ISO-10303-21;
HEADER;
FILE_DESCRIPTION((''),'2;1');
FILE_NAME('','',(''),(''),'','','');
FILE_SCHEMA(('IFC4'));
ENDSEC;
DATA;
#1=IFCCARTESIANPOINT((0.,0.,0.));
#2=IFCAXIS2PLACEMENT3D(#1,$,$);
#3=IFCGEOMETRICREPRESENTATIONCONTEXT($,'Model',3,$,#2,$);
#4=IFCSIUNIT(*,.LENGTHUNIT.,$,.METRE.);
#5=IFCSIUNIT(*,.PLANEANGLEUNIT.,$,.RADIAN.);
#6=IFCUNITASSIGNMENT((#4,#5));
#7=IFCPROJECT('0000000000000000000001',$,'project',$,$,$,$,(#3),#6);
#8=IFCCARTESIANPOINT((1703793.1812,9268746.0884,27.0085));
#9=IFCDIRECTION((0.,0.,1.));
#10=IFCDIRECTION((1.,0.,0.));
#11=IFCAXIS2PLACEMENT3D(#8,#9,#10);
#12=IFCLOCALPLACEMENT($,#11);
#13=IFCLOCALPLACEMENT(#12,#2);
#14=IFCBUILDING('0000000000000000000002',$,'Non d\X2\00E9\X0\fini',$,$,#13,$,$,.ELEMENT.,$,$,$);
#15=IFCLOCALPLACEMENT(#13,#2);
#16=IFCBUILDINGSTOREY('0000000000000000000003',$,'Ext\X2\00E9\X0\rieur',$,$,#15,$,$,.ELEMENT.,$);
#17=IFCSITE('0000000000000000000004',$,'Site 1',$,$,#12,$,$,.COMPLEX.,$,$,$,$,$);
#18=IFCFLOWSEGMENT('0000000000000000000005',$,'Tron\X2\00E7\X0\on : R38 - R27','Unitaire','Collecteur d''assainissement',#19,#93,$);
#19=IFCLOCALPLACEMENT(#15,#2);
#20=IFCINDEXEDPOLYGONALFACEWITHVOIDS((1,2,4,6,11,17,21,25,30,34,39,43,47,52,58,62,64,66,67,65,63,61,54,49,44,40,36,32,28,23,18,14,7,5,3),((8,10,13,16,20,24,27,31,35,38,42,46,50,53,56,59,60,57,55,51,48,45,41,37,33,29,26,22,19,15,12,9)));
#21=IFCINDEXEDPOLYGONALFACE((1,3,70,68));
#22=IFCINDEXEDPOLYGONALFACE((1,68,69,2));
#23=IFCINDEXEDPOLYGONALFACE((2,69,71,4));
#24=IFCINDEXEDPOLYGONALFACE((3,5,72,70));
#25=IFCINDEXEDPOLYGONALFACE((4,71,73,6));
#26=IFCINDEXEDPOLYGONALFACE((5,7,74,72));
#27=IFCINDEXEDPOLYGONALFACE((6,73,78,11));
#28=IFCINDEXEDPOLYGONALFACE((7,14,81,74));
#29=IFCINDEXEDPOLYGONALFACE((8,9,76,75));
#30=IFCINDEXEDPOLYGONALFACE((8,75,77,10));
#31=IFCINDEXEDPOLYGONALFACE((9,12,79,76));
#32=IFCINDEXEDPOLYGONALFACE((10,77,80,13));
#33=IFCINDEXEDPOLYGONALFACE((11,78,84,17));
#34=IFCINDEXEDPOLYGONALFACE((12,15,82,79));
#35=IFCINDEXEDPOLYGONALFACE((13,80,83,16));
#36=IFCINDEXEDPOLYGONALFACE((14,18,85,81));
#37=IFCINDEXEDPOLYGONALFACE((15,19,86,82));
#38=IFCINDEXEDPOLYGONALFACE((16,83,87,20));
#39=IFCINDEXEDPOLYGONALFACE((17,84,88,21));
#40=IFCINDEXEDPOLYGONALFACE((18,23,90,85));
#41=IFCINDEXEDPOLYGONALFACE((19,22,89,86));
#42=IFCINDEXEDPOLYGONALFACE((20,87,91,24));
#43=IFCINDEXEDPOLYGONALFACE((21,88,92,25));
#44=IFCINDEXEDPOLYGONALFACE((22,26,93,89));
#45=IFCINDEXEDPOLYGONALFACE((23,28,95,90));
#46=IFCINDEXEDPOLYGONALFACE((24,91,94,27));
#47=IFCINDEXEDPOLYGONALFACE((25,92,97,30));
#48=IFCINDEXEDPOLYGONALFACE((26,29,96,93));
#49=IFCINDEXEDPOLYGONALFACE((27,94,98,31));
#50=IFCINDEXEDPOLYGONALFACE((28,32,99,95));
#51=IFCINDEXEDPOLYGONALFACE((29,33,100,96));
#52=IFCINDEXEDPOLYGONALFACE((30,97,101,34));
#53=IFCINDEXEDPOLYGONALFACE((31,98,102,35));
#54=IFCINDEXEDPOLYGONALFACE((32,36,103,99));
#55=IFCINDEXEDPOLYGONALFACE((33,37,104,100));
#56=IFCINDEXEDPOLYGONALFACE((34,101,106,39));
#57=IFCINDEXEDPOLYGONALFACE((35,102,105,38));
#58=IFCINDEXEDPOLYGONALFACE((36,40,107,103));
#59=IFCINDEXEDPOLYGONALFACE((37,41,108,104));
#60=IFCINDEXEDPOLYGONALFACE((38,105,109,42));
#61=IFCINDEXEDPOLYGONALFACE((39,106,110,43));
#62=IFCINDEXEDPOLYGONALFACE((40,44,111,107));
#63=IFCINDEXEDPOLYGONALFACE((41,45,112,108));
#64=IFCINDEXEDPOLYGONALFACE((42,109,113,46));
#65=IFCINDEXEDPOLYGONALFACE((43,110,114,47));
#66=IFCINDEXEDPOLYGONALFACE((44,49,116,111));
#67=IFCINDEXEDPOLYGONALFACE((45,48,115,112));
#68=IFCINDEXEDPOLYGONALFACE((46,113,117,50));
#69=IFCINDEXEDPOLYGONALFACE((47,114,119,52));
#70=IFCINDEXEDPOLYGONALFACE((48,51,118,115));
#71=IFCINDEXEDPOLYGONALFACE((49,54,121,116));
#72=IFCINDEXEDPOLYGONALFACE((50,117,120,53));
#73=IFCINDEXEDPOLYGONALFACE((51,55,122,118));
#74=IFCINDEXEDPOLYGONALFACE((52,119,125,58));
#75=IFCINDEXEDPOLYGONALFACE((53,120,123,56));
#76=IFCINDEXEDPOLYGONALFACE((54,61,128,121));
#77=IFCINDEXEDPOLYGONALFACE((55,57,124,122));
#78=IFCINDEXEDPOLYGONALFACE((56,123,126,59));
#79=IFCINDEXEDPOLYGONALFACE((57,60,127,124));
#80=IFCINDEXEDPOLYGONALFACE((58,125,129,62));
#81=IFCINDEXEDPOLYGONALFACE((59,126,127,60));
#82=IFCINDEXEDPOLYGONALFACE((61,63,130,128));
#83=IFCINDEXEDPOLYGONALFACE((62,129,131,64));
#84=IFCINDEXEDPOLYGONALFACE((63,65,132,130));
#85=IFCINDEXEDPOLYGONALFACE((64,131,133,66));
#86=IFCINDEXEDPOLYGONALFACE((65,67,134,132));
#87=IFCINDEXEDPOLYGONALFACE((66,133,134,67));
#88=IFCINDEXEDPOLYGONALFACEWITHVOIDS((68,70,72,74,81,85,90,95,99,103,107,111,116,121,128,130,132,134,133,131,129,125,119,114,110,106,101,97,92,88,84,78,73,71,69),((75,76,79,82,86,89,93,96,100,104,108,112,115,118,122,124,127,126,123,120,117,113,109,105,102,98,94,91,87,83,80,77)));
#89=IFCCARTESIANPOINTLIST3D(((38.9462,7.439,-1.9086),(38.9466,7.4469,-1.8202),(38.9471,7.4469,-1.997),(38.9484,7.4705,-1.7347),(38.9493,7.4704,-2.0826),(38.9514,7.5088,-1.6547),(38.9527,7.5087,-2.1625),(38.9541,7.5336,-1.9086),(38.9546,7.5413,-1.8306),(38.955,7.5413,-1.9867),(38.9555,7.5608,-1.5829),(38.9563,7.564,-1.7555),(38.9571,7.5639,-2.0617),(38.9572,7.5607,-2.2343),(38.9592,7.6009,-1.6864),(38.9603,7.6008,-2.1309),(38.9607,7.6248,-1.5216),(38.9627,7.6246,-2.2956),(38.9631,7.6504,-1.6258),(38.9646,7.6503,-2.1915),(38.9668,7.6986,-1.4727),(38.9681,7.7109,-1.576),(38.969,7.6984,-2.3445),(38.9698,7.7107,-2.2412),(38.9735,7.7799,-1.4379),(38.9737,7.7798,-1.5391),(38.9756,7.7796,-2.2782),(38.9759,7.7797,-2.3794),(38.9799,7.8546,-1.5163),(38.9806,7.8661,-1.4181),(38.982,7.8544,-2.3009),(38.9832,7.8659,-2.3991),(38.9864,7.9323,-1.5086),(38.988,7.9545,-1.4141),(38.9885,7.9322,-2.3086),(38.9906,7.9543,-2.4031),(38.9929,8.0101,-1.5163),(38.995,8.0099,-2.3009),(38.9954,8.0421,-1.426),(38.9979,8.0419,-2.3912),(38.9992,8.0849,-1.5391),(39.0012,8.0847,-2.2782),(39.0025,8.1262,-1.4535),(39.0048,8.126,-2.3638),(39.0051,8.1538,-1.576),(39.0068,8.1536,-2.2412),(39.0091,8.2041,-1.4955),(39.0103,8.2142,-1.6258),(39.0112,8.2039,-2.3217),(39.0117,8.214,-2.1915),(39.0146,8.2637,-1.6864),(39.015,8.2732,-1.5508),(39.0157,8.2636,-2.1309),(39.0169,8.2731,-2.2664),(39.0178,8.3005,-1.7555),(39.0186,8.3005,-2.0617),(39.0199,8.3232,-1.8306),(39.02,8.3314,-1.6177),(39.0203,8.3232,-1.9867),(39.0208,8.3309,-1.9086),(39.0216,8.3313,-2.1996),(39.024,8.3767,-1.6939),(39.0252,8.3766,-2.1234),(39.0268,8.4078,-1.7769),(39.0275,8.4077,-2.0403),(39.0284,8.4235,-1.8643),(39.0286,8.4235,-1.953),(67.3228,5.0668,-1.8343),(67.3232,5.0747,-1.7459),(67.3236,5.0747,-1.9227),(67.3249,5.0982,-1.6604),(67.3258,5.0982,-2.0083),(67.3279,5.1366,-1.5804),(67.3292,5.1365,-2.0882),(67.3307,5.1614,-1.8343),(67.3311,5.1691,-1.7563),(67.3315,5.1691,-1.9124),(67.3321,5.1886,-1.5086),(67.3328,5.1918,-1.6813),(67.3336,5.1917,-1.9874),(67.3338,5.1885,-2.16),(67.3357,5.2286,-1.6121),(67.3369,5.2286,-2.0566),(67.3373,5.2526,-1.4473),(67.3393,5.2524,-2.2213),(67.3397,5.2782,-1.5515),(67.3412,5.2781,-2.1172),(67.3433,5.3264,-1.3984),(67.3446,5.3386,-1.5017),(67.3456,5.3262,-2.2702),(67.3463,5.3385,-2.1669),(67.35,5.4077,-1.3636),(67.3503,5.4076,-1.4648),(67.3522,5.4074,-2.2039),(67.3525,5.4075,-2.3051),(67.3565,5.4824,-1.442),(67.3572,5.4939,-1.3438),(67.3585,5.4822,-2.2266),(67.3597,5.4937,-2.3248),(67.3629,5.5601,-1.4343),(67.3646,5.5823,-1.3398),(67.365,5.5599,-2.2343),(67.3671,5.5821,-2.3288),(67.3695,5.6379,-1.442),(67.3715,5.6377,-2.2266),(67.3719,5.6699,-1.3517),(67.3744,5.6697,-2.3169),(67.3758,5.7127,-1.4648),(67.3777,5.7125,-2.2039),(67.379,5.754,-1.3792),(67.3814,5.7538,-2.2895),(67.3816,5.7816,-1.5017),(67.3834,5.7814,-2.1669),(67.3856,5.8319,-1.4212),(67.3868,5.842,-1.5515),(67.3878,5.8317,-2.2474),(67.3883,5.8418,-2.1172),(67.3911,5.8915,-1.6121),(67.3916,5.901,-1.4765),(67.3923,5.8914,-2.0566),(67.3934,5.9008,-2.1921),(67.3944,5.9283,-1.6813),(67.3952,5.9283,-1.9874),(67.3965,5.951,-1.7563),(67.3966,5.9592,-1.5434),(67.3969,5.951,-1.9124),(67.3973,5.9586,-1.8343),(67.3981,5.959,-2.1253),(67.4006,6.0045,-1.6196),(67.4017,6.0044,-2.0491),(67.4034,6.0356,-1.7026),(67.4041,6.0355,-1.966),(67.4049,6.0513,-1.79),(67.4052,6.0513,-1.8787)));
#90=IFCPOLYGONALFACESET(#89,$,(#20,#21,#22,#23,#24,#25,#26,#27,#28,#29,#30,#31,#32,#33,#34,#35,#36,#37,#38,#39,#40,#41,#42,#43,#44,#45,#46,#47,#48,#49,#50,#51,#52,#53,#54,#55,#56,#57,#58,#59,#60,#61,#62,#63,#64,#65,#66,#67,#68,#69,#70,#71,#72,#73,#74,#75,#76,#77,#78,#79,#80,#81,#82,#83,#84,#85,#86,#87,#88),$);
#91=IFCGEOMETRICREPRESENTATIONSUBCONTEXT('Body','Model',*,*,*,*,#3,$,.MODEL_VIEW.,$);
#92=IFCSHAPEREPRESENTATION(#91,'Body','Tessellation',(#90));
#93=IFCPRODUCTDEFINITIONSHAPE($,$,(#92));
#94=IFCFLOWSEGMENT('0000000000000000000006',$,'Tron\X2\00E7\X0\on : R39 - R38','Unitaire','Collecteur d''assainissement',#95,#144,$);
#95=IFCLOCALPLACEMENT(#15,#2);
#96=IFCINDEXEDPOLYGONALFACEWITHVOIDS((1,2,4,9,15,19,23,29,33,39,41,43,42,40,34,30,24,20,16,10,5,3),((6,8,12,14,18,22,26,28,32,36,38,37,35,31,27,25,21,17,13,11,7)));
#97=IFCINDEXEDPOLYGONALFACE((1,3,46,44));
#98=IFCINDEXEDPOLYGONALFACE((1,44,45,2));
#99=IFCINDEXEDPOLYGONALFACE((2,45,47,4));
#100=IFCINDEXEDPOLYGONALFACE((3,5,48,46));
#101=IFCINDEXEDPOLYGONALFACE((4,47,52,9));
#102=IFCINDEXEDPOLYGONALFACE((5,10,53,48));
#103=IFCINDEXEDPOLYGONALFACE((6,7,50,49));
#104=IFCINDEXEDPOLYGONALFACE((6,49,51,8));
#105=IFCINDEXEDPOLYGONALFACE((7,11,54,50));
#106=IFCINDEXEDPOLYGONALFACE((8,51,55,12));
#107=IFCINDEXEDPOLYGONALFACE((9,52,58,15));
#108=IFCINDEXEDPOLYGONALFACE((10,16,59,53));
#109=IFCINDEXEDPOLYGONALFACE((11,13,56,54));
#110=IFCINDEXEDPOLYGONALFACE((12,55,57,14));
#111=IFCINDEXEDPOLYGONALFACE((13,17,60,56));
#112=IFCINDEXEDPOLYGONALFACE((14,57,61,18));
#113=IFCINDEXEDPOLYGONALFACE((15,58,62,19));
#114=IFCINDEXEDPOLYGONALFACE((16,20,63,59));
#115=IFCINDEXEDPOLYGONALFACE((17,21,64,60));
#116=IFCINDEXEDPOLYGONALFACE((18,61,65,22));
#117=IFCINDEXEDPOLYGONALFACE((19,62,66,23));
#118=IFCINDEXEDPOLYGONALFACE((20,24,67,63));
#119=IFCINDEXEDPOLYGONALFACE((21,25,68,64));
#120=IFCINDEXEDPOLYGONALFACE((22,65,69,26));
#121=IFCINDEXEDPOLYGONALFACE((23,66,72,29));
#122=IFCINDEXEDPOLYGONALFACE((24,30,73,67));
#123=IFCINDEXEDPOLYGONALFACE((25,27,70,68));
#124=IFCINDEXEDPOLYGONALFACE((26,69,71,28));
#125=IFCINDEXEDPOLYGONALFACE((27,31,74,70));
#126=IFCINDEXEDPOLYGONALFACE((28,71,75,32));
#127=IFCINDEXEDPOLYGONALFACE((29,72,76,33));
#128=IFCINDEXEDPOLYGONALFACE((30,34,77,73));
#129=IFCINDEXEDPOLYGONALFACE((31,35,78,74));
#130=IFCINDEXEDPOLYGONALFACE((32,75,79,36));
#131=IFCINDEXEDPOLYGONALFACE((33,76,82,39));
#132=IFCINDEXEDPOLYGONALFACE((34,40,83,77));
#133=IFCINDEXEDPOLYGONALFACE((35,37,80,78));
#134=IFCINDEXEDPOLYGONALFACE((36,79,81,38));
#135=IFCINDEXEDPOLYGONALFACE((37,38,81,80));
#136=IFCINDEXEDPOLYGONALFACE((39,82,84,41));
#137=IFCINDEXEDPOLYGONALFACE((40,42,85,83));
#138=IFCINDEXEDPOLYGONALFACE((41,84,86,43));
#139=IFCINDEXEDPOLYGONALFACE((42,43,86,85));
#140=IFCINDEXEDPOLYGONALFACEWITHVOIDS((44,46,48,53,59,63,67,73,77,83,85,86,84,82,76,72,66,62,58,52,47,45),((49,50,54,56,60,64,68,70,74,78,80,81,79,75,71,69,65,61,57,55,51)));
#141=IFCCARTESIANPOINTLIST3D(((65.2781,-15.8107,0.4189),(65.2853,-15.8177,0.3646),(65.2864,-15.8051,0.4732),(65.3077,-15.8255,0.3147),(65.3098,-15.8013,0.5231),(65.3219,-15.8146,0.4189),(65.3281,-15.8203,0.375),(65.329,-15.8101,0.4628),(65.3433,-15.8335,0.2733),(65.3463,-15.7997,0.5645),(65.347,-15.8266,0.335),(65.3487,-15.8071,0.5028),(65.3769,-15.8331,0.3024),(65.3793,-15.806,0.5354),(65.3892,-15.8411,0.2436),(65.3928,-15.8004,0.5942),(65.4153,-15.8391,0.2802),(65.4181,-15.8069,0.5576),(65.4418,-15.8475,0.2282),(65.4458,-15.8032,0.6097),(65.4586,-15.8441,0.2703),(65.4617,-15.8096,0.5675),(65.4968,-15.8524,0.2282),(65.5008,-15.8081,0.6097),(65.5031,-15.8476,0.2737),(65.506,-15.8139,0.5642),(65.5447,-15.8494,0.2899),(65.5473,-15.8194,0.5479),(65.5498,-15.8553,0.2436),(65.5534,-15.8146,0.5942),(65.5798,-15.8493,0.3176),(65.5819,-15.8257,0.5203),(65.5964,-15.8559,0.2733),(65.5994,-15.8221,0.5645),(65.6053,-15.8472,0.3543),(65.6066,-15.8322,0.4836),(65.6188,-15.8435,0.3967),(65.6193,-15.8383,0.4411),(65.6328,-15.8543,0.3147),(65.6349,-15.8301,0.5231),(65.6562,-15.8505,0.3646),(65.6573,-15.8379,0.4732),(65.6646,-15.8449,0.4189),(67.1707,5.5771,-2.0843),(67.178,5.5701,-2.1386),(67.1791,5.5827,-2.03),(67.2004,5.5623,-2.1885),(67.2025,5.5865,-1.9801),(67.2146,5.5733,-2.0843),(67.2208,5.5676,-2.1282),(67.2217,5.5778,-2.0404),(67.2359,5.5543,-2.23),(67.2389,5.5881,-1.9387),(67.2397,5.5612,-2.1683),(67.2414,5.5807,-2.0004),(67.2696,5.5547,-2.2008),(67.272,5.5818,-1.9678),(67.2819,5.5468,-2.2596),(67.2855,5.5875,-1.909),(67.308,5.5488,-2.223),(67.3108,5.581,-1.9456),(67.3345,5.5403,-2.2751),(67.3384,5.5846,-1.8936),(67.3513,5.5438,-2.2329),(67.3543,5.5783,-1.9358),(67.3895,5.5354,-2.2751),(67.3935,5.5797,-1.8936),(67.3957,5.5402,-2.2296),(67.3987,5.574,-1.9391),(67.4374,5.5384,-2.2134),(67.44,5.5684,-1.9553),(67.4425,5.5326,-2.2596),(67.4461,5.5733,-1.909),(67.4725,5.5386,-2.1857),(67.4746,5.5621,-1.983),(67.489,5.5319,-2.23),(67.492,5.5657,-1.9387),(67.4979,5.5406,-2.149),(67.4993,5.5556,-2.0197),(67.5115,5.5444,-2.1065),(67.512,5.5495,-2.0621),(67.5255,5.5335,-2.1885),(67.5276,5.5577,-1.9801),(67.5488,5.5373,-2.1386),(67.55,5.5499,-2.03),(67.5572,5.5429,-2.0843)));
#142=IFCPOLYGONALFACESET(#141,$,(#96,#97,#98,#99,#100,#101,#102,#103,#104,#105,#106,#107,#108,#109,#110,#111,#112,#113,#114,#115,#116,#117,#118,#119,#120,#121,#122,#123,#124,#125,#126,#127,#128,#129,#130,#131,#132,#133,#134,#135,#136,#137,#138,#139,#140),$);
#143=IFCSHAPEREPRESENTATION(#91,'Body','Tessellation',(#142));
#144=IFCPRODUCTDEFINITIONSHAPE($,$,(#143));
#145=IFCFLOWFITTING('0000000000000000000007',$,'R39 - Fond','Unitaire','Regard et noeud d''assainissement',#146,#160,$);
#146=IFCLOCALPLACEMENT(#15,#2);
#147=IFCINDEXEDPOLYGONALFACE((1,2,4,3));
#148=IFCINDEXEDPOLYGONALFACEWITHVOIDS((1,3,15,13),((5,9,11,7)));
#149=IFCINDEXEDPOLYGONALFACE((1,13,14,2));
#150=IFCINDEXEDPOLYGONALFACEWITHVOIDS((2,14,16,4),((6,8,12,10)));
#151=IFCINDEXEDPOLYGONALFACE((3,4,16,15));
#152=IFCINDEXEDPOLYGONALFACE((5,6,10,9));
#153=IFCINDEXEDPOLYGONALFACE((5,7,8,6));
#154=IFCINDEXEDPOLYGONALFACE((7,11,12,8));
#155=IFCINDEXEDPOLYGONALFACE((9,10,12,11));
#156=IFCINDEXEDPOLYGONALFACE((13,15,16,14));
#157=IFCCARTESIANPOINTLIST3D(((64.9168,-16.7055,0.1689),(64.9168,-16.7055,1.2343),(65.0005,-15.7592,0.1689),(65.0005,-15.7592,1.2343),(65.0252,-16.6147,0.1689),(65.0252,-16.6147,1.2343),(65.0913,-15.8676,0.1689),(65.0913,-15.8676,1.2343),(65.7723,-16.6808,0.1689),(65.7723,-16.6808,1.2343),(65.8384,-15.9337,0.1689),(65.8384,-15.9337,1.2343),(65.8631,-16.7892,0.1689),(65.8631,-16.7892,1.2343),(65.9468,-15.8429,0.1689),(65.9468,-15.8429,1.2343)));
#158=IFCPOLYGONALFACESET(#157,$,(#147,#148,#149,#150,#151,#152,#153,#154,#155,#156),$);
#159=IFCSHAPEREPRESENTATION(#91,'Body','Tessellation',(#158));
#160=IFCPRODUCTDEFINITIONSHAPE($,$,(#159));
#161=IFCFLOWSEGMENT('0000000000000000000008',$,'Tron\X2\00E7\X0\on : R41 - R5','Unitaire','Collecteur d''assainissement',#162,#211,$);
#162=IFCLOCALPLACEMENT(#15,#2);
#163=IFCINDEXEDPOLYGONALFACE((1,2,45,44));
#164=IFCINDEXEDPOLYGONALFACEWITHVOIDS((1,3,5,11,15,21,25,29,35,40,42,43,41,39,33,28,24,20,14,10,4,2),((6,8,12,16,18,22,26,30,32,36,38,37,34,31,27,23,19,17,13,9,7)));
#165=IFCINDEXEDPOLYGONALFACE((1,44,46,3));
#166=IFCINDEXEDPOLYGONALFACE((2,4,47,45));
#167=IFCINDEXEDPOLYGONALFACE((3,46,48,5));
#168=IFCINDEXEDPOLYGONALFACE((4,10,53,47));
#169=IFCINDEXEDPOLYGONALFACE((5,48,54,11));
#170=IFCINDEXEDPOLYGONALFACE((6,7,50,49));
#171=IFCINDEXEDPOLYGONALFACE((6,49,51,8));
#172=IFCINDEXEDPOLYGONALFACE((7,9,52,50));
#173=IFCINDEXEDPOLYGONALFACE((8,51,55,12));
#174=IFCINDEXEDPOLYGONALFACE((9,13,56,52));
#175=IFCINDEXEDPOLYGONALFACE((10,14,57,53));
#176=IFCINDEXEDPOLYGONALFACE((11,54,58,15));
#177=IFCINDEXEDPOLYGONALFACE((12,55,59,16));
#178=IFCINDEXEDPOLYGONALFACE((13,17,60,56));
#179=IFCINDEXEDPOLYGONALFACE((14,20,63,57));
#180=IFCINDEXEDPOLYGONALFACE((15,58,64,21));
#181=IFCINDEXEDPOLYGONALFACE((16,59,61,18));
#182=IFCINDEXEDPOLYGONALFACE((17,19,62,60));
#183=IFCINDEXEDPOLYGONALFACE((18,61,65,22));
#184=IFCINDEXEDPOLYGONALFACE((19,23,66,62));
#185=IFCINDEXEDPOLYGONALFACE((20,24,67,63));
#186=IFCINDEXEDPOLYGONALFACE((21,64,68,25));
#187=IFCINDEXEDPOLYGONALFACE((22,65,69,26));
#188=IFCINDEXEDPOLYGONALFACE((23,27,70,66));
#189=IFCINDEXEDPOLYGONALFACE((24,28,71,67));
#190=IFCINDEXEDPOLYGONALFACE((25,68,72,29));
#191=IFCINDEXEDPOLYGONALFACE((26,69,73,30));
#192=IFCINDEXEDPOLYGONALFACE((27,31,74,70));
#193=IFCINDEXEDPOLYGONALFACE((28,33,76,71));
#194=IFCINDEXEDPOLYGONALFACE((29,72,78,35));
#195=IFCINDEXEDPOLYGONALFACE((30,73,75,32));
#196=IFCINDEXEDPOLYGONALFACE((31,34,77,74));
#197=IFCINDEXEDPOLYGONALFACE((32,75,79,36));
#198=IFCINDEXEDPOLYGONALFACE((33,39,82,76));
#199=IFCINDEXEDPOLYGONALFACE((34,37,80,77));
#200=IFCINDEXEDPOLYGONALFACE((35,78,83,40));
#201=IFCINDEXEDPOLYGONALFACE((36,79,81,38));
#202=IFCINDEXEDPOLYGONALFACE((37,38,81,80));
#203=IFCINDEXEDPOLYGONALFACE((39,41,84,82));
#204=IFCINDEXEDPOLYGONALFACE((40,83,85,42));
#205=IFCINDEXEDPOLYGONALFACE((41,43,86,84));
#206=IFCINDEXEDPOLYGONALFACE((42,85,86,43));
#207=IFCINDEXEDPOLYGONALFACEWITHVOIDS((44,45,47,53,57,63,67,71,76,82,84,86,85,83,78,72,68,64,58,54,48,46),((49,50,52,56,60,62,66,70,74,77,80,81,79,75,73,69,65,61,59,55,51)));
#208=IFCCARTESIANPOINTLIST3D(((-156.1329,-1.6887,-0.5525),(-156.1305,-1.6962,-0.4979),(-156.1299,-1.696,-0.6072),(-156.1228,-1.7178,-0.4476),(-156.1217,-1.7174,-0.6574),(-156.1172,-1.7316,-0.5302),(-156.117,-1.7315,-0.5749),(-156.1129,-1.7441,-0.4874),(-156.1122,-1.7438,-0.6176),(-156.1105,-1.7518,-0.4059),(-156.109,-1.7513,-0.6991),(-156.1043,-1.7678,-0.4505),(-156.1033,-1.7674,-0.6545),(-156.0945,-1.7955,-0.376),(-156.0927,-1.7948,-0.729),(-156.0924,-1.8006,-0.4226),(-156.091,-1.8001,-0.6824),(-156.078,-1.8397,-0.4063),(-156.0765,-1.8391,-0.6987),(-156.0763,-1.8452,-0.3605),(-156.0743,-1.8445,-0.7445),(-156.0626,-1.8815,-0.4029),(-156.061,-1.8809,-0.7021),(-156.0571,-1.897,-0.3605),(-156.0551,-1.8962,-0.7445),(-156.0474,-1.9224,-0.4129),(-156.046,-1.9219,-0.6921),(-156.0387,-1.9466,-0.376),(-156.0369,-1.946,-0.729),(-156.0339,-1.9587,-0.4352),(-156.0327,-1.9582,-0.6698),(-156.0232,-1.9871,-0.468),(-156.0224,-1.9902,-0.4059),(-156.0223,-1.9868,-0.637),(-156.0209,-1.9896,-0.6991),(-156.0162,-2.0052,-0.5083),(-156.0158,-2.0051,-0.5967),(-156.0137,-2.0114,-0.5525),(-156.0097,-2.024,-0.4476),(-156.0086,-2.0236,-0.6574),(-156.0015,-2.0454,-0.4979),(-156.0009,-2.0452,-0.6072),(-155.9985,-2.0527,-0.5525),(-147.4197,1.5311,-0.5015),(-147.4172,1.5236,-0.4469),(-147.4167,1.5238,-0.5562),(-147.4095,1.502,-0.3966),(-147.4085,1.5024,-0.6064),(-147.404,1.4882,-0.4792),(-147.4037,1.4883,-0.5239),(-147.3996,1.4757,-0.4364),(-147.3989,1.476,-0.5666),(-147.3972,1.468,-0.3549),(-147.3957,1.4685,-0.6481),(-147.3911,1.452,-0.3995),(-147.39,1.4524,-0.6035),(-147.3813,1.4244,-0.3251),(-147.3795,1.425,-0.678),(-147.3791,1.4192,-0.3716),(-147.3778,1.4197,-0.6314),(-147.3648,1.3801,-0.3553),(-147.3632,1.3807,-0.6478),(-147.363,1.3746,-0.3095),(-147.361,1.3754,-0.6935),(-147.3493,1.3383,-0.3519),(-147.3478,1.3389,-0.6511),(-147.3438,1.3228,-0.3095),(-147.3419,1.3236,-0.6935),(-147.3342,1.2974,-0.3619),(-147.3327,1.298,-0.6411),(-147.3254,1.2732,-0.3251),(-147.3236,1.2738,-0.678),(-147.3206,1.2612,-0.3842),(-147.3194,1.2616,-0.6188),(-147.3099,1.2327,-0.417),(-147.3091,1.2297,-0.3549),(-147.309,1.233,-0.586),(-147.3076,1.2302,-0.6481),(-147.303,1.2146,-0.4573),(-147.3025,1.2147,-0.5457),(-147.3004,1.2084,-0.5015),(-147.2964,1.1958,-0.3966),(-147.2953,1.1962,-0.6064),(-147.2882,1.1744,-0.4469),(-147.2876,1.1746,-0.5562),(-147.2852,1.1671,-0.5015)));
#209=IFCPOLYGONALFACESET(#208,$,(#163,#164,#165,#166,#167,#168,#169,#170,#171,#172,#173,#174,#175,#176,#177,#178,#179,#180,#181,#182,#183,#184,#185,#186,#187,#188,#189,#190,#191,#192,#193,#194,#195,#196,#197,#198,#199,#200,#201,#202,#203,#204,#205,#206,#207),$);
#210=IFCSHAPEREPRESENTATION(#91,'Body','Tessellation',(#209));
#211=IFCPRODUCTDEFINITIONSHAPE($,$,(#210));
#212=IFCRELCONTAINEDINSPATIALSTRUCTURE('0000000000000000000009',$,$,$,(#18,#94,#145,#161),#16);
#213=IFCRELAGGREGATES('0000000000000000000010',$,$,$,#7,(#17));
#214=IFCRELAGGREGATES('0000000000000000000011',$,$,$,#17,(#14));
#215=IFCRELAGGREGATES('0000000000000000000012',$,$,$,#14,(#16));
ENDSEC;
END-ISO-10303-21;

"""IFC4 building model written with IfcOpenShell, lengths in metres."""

from ifc_helpers import new_model, si_unit, frame, origin, origin_2d, place, context, subcontext, project, spatial, hollow_rectangle, hollow_circle, extrude, element, save


model = new_model("IFC4")

# Units and contexts
model_context = context("Model", 3, world=origin())
body_context = subcontext(model_context, "Body", "Model", "MODEL_VIEW")
ifc_project = project(units=[si_unit("LENGTHUNIT", "METRE"), si_unit("PLANEANGLEUNIT", "RADIAN")], contexts=[model_context])

# Site, building, storey
site_placement = place(None, frame((1703793.1812, 9268746.0884, 27.0085), z_axis=(0.0, 0.0, 1.0), x_axis=(1.0, 0.0, 0.0)))
site = spatial("IfcSite", under=ifc_project, at=site_placement, Name="Site 1", CompositionType="COMPLEX")
building_placement = place(site_placement, origin())
building = spatial("IfcBuilding", under=site, at=building_placement, Name="Non défini", CompositionType="ELEMENT")
storey_placement = place(building_placement, origin())
storey = spatial("IfcBuildingStorey", under=building, at=storey_placement, Name="Extérieur", CompositionType="ELEMENT")

# Flow segments
flow_segment_1_placement = place(storey_placement, origin())
element("IfcFlowSegment", 1, at=flow_segment_1_placement, inside=storey, Name="Tronçon : R38 - R27", Description="Unitaire", ObjectType="Collecteur d'assainissement", context=body_context, shape_type="SweptSolid", body=[
    extrude(hollow_circle(Radius=0.495, WallThickness=0.095, at=origin_2d()), frame((67.364, 5.56, -1.8343), z_axis=(-0.996521, 0.083307, -0.002609), x_axis=(-0.083307, -0.996524, 0.0)), (0.0, 0.0, 1.0), 28.4756),
])
flow_segment_2_placement = place(storey_placement, origin())
element("IfcFlowSegment", 2, at=flow_segment_2_placement, inside=storey, Name="Tronçon : R39 - R38", Description="Unitaire", ObjectType="Collecteur d'assainissement", context=body_context, shape_type="SweptSolid", body=[
    extrude(hollow_circle(Radius=0.194, WallThickness=0.044, at=origin_2d()), frame((65.4713, -15.8278, 0.4189), z_axis=(0.087556, 0.989406, -0.115801), x_axis=(-0.996107, 0.088149, 0.0)), (0.0, 0.0, 1.0), 21.6169),
])

# Flow fitting
flow_fitting_1_placement = place(storey_placement, origin())
element("IfcFlowFitting", 3, at=flow_fitting_1_placement, inside=storey, Name="R39 - Fond", Description="Unitaire", ObjectType="Regard et noeud d'assainissement", context=body_context, shape_type="SweptSolid", body=[
    extrude(hollow_rectangle(XDim=0.95, YDim=0.95, WallThickness=0.1, at=origin_2d()), frame((65.4318, -16.2742, 0.1689), z_axis=(0.0, 0.0, 1.0), x_axis=(0.088149, 0.996107, 0.0)), (0.0, 0.0, 1.0), 1.0654),
])

# Flow segment
flow_segment_3_placement = place(storey_placement, origin())
element("IfcFlowSegment", 4, at=flow_segment_3_placement, inside=storey, Name="Tronçon : R41 - R5", Description="Unitaire", ObjectType="Collecteur d'assainissement", context=body_context, shape_type="SweptSolid", body=[
    extrude(hollow_circle(Radius=0.194, WallThickness=0.044, at=origin_2d()), frame((-147.3524, 1.3491, -0.5015), z_axis=(-0.937991, -0.346616, -0.005489), x_axis=(0.346621, -0.938005, 0.0)), (0.0, 0.0, 1.0), 9.2893),
])

save(model, "model.ifc")
